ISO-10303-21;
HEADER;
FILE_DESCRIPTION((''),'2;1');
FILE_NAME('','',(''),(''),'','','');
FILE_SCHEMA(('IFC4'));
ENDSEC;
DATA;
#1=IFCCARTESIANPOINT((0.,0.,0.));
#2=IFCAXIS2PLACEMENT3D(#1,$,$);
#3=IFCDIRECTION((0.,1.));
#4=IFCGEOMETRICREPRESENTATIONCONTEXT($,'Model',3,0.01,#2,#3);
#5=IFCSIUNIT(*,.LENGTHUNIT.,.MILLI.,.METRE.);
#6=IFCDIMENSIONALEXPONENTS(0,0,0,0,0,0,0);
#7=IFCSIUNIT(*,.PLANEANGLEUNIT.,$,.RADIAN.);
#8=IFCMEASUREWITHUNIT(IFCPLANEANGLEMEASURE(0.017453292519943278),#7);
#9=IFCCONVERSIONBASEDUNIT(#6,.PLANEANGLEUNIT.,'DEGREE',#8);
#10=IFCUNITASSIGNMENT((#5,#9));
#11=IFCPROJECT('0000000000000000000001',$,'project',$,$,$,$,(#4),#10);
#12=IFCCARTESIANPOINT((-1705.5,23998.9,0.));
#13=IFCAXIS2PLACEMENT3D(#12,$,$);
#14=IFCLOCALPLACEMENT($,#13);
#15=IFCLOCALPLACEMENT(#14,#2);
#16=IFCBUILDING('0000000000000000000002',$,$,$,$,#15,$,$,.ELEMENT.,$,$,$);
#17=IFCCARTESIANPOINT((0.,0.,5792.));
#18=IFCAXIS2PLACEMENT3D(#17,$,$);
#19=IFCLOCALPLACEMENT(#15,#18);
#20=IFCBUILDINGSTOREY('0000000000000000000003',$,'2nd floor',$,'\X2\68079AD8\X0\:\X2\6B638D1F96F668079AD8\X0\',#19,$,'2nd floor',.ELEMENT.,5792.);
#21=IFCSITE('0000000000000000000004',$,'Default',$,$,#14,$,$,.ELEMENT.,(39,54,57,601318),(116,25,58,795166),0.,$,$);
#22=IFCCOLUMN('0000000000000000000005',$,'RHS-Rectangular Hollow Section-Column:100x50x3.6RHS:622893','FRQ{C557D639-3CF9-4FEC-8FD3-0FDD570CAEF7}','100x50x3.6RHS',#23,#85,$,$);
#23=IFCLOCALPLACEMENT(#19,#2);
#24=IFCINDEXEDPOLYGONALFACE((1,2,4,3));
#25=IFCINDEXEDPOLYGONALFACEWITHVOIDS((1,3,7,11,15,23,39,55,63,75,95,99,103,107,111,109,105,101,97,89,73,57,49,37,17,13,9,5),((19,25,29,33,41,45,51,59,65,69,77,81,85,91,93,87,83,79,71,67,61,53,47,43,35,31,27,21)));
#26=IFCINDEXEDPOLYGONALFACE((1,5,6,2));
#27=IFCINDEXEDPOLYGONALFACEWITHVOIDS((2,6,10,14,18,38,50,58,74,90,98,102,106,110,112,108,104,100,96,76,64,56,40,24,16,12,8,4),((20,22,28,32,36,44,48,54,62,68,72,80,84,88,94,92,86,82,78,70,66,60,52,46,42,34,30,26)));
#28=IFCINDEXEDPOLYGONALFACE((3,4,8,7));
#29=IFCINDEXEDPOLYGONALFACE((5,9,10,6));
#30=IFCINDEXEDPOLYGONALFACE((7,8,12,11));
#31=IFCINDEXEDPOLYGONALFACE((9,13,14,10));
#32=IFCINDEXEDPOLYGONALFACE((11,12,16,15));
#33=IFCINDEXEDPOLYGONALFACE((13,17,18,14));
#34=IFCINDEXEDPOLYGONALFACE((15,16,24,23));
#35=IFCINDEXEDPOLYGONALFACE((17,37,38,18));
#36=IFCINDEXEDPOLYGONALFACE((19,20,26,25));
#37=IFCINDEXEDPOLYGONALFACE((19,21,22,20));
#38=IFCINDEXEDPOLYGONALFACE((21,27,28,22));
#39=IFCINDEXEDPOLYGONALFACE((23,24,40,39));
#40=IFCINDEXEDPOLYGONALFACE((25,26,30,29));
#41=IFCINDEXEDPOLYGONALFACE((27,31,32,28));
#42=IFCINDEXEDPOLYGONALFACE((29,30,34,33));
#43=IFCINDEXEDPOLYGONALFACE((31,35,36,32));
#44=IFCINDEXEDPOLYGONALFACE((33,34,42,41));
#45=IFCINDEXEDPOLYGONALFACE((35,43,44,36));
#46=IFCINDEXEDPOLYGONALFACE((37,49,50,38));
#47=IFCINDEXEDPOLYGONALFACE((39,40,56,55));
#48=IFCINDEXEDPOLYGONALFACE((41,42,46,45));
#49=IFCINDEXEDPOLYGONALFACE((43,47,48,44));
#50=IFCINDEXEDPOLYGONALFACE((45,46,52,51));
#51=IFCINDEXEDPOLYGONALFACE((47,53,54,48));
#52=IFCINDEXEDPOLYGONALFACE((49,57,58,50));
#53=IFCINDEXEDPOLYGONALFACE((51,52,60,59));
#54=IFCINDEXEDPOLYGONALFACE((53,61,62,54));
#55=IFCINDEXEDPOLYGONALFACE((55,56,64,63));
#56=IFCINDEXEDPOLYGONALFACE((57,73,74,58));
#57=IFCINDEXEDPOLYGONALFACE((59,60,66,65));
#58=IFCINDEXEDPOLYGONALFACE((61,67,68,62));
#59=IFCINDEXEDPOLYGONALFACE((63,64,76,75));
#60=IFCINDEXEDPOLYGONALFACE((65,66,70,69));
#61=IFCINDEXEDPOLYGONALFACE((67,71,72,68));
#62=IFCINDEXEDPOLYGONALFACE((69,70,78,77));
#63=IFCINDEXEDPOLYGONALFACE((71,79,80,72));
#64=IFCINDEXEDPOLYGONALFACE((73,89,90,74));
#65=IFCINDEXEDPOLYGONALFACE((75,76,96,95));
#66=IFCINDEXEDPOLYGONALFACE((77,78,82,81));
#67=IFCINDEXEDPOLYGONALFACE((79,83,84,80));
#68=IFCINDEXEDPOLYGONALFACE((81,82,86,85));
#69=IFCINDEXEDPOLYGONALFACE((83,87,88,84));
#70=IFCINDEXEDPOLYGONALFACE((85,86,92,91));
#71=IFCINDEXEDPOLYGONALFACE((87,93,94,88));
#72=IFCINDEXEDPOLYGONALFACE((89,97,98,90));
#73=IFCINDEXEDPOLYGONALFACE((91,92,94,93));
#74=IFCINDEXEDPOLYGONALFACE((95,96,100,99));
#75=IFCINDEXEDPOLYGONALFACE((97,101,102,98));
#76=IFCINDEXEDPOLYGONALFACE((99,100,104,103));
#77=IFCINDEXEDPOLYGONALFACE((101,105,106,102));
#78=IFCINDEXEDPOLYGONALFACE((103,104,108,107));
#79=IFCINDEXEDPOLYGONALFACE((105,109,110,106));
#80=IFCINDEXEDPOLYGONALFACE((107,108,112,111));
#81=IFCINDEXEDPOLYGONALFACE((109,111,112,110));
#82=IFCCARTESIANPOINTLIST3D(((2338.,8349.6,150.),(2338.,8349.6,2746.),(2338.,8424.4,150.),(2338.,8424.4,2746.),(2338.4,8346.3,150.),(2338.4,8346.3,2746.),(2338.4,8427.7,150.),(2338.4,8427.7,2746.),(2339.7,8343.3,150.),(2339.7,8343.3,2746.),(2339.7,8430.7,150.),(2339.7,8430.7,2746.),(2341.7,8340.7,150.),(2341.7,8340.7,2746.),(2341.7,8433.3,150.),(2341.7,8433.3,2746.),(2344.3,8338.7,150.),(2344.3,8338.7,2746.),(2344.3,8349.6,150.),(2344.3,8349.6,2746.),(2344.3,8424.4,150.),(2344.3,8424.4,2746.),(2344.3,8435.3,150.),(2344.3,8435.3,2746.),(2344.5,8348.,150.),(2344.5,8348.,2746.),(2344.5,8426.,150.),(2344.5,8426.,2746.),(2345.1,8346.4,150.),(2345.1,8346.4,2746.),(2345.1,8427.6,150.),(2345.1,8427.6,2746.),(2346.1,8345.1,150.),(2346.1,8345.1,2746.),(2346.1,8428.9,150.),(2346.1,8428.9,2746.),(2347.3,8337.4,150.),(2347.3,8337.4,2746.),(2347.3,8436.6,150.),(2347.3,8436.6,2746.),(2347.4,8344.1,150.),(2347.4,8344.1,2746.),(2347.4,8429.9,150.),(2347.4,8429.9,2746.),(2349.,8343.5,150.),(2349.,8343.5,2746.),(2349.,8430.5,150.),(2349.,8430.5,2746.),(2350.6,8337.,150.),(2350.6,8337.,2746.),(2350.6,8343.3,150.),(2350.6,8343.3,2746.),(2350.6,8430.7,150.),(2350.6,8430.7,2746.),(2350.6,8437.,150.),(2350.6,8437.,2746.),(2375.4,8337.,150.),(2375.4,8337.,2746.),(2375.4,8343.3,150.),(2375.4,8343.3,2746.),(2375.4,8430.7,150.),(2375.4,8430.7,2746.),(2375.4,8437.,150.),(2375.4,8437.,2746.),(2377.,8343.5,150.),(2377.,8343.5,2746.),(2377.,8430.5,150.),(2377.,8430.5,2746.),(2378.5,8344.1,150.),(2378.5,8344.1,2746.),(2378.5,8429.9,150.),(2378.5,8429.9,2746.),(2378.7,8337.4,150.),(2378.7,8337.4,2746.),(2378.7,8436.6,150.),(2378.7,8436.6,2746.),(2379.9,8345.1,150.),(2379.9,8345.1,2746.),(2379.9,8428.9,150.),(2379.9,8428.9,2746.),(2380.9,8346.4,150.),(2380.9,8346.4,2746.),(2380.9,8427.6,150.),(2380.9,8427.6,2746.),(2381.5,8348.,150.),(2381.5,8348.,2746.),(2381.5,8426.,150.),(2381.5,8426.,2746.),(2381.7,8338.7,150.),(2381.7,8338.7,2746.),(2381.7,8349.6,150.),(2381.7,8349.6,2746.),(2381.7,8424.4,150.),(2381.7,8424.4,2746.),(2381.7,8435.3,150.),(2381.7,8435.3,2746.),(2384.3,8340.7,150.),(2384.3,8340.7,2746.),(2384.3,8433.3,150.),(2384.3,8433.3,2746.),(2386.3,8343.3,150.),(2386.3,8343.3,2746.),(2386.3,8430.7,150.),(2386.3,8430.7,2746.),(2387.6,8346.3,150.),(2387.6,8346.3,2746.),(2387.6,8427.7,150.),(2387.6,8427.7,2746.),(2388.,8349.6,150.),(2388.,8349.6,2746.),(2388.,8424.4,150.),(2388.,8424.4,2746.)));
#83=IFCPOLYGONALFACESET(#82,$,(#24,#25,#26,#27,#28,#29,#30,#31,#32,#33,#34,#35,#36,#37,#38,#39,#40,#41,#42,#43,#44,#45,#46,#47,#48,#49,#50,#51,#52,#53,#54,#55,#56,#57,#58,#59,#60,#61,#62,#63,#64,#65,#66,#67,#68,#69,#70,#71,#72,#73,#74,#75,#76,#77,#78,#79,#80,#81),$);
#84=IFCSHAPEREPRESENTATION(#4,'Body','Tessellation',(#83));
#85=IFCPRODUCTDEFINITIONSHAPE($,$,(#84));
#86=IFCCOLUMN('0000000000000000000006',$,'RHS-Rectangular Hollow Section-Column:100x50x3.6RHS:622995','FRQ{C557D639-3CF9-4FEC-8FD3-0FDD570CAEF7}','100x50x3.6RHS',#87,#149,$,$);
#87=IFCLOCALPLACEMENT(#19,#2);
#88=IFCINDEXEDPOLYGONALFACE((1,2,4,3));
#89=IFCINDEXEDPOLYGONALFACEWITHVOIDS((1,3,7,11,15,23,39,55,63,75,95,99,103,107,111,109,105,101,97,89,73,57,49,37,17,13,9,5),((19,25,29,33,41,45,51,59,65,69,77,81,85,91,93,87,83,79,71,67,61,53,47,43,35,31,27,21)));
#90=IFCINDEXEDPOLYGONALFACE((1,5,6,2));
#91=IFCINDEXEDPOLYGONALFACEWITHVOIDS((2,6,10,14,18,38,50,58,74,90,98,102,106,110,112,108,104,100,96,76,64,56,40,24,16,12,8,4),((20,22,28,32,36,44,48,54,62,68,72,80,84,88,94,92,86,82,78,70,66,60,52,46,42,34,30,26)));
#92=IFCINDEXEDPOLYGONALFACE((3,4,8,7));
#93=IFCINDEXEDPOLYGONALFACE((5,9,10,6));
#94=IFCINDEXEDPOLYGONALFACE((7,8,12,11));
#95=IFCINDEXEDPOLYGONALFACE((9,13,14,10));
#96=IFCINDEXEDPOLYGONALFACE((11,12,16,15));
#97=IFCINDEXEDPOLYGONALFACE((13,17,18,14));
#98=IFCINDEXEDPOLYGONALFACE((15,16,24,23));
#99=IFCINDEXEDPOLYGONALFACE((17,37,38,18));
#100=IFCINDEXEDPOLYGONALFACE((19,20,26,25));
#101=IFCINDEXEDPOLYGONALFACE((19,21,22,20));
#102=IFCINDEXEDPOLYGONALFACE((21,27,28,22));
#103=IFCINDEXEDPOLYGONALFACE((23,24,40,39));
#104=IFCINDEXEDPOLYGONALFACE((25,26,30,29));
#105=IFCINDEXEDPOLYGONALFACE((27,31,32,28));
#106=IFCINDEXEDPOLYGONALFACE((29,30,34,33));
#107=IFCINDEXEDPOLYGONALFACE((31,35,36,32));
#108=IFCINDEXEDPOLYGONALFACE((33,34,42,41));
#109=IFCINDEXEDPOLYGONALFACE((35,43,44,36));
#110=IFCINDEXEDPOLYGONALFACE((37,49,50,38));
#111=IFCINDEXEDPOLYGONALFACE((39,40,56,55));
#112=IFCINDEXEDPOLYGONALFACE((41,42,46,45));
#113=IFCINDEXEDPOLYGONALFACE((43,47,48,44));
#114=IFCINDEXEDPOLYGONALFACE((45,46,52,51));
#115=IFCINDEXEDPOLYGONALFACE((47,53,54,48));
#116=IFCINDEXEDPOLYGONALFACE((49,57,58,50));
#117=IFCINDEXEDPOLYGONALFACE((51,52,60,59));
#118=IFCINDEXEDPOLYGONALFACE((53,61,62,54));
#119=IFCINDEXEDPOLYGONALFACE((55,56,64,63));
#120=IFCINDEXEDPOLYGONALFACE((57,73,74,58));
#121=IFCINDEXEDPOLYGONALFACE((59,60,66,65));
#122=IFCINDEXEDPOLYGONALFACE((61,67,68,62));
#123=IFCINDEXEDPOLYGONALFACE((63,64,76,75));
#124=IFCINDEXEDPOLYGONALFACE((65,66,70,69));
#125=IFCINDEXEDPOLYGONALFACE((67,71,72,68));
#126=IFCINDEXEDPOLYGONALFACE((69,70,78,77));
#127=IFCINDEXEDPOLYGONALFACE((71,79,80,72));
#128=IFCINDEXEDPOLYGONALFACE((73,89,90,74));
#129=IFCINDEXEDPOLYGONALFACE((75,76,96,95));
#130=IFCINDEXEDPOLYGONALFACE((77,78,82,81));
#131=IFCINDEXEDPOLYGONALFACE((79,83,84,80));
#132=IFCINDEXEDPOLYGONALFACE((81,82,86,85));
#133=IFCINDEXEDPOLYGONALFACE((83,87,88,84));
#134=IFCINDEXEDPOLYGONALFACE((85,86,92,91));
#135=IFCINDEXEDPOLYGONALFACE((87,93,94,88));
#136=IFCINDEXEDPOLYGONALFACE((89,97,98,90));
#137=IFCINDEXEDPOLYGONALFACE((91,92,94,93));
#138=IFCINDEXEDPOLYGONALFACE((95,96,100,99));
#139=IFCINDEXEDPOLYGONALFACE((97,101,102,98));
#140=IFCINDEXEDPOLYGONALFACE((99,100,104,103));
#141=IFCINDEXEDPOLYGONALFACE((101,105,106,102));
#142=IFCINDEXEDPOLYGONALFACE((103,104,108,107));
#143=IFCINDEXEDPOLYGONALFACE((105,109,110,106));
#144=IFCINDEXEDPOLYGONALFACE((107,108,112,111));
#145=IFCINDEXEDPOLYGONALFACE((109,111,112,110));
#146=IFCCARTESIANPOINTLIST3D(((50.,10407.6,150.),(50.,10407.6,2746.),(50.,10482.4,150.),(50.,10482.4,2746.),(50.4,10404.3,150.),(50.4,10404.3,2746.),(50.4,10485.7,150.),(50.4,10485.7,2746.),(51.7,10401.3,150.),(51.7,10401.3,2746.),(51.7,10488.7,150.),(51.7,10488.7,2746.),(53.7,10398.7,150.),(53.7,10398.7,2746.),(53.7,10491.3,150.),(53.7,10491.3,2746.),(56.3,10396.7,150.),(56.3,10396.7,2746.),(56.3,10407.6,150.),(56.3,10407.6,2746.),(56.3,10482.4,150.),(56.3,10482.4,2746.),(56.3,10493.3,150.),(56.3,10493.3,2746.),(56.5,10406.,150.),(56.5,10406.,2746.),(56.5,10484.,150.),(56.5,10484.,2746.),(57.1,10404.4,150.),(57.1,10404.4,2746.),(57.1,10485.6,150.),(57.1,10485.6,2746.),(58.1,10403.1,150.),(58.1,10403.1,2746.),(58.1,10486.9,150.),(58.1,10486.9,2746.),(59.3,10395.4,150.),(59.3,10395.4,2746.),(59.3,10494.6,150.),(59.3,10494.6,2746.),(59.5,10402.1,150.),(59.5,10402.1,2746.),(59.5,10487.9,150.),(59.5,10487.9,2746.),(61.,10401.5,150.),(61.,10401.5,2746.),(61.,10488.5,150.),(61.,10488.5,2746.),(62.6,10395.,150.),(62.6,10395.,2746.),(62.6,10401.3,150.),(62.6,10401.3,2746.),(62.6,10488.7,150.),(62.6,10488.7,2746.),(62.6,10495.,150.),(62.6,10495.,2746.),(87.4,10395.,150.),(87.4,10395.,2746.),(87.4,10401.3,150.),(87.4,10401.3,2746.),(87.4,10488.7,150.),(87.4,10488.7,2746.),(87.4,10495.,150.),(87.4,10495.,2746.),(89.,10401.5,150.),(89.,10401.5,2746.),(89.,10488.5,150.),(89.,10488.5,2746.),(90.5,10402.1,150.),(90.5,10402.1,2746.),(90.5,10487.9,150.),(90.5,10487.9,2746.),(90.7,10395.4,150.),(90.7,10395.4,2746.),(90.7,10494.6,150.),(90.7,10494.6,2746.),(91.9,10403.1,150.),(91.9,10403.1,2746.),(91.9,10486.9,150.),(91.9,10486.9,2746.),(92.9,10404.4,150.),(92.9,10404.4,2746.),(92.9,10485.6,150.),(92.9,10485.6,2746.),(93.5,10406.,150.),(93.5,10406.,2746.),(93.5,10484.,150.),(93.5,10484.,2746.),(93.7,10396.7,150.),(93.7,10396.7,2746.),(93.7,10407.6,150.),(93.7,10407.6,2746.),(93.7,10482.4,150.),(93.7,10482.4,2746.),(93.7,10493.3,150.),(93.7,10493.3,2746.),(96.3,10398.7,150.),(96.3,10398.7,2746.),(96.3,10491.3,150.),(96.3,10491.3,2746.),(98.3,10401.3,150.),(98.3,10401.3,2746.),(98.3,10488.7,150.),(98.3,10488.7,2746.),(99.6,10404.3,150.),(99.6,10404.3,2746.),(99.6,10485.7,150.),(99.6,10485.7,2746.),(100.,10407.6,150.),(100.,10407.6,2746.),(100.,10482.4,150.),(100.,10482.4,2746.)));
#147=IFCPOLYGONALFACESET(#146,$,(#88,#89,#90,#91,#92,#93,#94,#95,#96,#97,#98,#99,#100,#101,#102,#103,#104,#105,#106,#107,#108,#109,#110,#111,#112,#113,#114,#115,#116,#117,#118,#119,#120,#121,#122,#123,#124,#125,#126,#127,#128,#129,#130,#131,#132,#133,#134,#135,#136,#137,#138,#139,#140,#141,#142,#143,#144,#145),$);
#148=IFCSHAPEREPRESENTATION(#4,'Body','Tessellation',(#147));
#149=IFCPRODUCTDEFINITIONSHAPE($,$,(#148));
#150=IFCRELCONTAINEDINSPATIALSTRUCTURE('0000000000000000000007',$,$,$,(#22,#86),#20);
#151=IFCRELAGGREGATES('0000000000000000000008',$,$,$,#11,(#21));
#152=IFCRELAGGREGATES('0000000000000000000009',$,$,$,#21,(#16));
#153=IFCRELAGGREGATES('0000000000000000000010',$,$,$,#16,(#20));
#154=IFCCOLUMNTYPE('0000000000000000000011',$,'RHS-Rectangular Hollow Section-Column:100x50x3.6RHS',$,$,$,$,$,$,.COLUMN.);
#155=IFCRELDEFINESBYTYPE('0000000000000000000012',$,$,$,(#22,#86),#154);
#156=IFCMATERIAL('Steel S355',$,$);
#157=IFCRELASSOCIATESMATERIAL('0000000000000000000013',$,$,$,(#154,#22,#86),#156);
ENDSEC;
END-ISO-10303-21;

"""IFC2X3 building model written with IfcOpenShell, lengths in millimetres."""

from ifc_helpers import new_model, entity, si_unit, converted_unit, direction, frame, origin, origin_2d, place, context, project, spatial, hollow_rectangle, extrude, clip, halfspace, material, type_object, element, save


model = new_model("IFC2X3")

# Units and contexts
model_context = context("Model", 3, precision=0.01, world=origin(), true_north=direction((0.0, 1.0)))
ifc_project = project(units=[si_unit("LENGTHUNIT", "METRE", prefix="MILLI"), converted_unit("PLANEANGLEUNIT", "DEGREE", entity("IfcPlaneAngleMeasure", 0.017453292519943278), si_unit("PLANEANGLEUNIT", "RADIAN"), dimensions=[0, 0, 0, 0, 0, 0, 0])], contexts=[model_context])

# Site, building, storey
site_placement = place(None, frame((-1705.5, 23998.9, 0.0)))
site = spatial("IfcSite", under=ifc_project, at=site_placement, Name="Default", CompositionType="ELEMENT", RefLatitude=(39, 54, 57, 601318), RefLongitude=(116, 25, 58, 795166), RefElevation=0.0)
building_placement = place(site_placement, origin())
building = spatial("IfcBuilding", under=site, at=building_placement, CompositionType="ELEMENT")
storey_placement = place(building_placement, frame((0.0, 0.0, 5792.0)))
storey = spatial("IfcBuildingStorey", under=building, at=storey_placement, Name="2nd floor", ObjectType="标高:正负零标高", LongName="2nd floor", CompositionType="ELEMENT", Elevation=5792.0)

# Columns
ifc_material_1 = material(Name="Steel S355")
column_type = type_object("IfcColumnType", Name="RHS-Rectangular Hollow Section-Column:100x50x3.6RHS", PredefinedType="COLUMN", material=ifc_material_1)
column_1_placement = place(storey_placement, frame((2363.0, 8387.0, 2746.0), z_axis=(0.0, 0.0, 1.0), x_axis=(-1.0, 0.0, 0.0)))
element("IfcColumn", 1, at=column_1_placement, inside=storey, type_object=column_type, material=ifc_material_1, Name="RHS-Rectangular Hollow Section-Column:100x50x3.6RHS:622893", Description="FRQ{C557D639-3CF9-4FEC-8FD3-0FDD570CAEF7}", ObjectType="100x50x3.6RHS", context=model_context, shape_type="Clipping", body=[
    clip(extrude(hollow_rectangle(XDim=50.0, YDim=100.0, WallThickness=6.3, InnerFilletRadius=6.3, OuterFilletRadius=12.6, at=origin_2d()), origin(), (0.0, 0.0, -1.0), 2651.9), halfspace(frame((2363.0, 8387.0, -2596.0), z_axis=(0.0, 0.0, 1.0), x_axis=(-1.0, 0.0, 0.0)), True)),
])
column_2_placement = place(storey_placement, frame((75.0, 10445.0, 2746.0), z_axis=(0.0, 0.0, 1.0), x_axis=(-1.0, 0.0, 0.0)))
element("IfcColumn", 2, at=column_2_placement, inside=storey, type_object=column_type, material=ifc_material_1, Name="RHS-Rectangular Hollow Section-Column:100x50x3.6RHS:622995", Description="FRQ{C557D639-3CF9-4FEC-8FD3-0FDD570CAEF7}", ObjectType="100x50x3.6RHS", context=model_context, shape_type="Clipping", body=[
    clip(extrude(hollow_rectangle(XDim=50.0, YDim=100.0, WallThickness=6.3, InnerFilletRadius=6.3, OuterFilletRadius=12.6, at=origin_2d()), origin(), (0.0, 0.0, -1.0), 2651.9), halfspace(frame((75.0, 10445.0, -2596.0), z_axis=(0.0, 0.0, 1.0), x_axis=(-1.0, 0.0, 0.0)), True)),
])

save(model, "model.ifc")
